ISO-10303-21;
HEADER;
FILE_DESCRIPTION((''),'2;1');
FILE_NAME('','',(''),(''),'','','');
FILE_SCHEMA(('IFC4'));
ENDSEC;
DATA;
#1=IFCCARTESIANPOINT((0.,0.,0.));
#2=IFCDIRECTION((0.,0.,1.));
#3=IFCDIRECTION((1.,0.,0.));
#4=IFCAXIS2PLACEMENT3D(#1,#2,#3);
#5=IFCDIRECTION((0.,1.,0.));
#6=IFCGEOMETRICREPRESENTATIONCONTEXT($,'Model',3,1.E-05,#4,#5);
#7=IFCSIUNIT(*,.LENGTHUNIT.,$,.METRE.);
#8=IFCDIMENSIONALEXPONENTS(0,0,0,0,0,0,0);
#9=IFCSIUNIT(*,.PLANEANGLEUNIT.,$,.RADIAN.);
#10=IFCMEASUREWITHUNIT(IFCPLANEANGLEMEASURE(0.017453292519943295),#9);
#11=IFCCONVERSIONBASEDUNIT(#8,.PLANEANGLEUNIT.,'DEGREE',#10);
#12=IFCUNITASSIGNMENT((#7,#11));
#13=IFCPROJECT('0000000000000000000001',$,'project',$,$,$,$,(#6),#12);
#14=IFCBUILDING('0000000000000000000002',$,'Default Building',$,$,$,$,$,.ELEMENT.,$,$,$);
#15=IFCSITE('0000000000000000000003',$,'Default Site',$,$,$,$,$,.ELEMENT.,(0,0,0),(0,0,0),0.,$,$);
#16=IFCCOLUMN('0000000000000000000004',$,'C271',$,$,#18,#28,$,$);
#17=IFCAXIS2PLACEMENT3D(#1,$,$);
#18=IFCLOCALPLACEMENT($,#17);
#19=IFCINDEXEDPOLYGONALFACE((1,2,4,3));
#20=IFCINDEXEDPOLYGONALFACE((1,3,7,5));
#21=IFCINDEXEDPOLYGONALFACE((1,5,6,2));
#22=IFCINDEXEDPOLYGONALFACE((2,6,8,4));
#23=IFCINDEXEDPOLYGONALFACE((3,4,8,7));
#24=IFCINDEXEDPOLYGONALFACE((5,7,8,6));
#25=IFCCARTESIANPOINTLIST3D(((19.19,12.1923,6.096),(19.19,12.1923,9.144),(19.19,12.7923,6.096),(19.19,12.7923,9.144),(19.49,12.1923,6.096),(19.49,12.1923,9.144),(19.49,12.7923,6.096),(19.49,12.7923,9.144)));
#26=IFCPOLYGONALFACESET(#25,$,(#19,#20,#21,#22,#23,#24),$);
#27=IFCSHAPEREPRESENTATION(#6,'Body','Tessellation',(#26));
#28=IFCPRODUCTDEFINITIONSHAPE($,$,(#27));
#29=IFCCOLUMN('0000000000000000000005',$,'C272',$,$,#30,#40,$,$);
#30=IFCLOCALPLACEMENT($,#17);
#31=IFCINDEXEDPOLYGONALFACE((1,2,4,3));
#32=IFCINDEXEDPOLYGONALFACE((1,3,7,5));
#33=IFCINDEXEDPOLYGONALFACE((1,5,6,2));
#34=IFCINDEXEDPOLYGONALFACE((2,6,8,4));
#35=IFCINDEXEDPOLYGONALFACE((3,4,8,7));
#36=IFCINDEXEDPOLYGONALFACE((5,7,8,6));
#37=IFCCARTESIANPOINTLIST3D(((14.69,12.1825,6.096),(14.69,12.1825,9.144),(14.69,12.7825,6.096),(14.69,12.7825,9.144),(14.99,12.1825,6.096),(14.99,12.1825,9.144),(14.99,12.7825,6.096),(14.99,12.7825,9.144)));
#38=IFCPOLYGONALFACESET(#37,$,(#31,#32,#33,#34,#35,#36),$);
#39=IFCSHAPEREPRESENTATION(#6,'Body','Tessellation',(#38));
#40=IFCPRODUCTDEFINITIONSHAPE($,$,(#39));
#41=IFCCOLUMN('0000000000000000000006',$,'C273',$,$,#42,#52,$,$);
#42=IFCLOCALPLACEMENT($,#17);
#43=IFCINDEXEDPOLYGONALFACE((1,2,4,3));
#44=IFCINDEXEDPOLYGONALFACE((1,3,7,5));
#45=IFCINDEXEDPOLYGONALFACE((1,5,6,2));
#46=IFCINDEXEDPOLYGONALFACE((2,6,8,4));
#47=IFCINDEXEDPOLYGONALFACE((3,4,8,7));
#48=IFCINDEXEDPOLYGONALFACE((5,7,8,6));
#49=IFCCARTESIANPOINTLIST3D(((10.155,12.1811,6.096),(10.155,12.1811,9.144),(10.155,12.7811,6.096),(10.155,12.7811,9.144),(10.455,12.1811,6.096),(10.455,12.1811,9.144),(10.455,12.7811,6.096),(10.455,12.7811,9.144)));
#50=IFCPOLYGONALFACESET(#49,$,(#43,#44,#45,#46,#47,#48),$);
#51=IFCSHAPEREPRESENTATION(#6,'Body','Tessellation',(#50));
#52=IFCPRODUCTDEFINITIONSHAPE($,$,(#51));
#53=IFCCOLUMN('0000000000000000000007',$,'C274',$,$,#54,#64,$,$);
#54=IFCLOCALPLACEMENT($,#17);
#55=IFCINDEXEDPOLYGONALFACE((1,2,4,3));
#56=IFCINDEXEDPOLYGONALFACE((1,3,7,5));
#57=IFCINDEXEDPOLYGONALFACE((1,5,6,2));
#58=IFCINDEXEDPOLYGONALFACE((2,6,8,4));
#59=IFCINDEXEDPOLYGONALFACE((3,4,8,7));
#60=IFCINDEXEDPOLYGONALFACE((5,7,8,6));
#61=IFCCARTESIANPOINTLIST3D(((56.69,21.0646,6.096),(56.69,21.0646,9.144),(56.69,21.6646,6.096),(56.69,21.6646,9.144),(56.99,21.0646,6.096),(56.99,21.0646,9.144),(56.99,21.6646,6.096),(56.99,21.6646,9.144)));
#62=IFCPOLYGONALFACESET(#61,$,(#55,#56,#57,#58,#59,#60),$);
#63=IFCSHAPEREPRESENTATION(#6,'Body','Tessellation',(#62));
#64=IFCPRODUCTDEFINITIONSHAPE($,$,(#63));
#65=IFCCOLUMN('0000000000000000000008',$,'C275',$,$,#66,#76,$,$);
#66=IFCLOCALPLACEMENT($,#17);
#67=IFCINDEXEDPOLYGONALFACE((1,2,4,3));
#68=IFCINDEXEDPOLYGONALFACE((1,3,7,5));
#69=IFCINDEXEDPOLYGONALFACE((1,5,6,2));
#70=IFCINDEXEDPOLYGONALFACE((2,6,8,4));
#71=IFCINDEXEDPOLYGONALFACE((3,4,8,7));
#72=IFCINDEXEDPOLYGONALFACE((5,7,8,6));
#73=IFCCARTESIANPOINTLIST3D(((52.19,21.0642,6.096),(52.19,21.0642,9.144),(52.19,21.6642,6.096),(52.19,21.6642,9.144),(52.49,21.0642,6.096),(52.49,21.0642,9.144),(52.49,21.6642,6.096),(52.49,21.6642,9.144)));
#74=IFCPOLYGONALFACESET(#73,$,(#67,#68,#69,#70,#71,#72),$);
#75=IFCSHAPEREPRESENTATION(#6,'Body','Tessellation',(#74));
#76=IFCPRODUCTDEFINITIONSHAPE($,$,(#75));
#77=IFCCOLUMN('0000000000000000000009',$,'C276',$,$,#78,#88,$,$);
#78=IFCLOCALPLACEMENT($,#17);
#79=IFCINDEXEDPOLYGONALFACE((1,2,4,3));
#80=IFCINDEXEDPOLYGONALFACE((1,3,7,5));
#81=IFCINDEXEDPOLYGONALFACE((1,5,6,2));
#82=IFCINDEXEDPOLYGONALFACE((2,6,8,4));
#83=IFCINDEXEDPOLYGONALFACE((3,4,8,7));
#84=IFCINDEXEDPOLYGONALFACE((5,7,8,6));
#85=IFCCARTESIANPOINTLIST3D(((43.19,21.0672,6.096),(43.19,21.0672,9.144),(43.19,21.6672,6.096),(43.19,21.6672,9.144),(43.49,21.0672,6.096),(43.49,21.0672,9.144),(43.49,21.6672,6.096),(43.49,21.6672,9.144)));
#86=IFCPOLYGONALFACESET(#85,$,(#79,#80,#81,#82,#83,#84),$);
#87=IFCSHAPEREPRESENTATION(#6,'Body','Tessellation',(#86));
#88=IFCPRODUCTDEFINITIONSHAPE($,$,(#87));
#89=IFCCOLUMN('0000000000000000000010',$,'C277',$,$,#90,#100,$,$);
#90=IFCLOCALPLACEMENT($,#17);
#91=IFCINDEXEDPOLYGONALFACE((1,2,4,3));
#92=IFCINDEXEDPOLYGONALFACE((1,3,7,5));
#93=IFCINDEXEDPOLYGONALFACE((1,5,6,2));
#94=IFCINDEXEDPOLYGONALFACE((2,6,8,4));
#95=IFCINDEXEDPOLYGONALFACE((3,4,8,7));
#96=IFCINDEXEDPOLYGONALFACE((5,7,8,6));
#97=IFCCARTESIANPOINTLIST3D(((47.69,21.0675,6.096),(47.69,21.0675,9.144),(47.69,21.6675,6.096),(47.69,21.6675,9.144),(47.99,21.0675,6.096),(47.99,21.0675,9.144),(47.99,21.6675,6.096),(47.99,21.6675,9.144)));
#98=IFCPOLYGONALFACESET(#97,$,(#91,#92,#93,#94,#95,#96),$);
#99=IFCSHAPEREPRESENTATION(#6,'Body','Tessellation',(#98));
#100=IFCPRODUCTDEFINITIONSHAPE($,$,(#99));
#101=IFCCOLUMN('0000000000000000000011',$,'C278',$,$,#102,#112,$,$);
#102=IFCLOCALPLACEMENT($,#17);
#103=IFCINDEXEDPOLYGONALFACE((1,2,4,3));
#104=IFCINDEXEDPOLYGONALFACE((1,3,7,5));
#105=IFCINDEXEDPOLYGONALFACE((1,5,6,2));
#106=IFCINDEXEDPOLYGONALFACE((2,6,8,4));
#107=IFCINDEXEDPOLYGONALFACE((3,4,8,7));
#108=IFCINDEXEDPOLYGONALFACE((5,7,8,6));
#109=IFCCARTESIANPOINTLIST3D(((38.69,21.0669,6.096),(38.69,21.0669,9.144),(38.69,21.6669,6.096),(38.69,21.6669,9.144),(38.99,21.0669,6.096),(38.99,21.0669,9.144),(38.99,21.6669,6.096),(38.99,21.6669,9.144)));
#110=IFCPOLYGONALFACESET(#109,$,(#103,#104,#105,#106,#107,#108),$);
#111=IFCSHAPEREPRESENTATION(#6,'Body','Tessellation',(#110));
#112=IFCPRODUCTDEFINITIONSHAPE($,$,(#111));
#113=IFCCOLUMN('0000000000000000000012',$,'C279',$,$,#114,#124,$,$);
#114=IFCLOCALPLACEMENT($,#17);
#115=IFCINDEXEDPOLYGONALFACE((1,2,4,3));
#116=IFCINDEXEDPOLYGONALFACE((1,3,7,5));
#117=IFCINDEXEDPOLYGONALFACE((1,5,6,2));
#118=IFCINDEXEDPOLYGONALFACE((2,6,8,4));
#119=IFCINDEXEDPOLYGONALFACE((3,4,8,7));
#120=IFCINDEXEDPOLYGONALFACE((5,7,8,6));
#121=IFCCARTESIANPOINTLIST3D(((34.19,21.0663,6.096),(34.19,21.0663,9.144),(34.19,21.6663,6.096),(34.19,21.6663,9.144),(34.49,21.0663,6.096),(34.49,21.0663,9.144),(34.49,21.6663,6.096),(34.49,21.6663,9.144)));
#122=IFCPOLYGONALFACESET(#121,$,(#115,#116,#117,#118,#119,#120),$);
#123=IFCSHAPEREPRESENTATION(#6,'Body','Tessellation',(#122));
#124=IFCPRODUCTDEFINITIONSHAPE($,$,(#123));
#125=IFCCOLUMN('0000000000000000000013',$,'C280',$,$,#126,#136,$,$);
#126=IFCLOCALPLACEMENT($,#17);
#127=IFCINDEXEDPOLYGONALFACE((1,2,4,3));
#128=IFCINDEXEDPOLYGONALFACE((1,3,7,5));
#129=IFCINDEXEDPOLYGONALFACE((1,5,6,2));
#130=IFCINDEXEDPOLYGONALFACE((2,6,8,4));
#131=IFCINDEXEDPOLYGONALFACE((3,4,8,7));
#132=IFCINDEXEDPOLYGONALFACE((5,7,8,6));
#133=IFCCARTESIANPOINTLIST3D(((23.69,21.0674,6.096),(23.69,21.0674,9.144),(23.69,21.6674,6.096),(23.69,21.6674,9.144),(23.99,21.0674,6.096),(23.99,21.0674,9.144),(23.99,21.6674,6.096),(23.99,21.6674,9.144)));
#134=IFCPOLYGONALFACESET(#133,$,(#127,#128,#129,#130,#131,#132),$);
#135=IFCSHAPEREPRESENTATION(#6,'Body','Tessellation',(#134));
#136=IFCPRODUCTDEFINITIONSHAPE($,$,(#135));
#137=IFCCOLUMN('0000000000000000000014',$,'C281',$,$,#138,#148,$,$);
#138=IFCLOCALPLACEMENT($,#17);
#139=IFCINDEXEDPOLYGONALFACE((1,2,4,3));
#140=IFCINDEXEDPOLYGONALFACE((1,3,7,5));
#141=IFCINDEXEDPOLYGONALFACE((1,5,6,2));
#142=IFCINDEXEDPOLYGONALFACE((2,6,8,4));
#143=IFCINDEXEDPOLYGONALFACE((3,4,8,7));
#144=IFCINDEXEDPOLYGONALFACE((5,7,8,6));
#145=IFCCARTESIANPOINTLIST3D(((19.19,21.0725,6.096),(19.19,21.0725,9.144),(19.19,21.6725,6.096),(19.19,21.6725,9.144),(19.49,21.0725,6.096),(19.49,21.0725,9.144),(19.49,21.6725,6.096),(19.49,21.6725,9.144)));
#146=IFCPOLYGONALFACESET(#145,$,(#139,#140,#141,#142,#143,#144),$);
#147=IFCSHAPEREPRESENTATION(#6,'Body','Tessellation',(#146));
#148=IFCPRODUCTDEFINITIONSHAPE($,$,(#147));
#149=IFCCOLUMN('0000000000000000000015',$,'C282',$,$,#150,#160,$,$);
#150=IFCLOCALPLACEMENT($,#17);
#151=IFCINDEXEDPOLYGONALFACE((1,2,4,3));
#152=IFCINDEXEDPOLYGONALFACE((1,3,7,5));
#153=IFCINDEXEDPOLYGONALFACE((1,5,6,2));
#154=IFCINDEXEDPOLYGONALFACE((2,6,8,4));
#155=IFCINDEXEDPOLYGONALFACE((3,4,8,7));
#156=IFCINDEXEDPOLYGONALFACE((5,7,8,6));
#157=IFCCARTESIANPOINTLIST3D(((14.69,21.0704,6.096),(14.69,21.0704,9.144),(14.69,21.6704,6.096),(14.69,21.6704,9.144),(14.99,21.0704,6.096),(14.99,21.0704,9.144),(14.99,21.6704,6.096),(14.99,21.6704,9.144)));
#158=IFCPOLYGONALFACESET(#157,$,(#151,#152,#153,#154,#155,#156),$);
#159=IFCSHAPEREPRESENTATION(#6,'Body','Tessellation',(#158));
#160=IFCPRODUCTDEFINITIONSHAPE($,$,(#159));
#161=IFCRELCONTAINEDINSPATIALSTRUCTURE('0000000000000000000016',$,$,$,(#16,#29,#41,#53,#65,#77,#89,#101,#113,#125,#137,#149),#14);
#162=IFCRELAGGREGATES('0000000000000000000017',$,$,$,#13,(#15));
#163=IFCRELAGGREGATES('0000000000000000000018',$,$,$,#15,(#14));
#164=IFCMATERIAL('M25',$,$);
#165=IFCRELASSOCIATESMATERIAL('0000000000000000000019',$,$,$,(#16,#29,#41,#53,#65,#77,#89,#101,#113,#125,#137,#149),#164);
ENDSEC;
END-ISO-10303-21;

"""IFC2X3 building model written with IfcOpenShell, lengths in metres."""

from ifc_helpers import new_model, entity, si_unit, converted_unit, direction, frame, frame_2d, origin_with_axes, place, context, project, spatial, rectangle, extrude, material, element, save


model = new_model("IFC2X3")

# Units and contexts
model_context = context("Model", 3, precision=1e-05, world=origin_with_axes(), true_north=direction((0.0, 1.0, 0.0)))
ifc_project = project(units=[si_unit("LENGTHUNIT", "METRE"), converted_unit("PLANEANGLEUNIT", "DEGREE", entity("IfcPlaneAngleMeasure", 0.017453292519943295), si_unit("PLANEANGLEUNIT", "RADIAN"), dimensions=[0, 0, 0, 0, 0, 0, 0])], contexts=[model_context])

# Site, building
site = spatial("IfcSite", under=ifc_project, Name="Default Site", CompositionType="ELEMENT", RefLatitude=(0, 0, 0), RefLongitude=(0, 0, 0), RefElevation=0.0)
building = spatial("IfcBuilding", under=site, Name="Default Building", CompositionType="ELEMENT")

# Columns
ifc_material = material(Name="M25")
placement = place(None, origin_with_axes())
element("IfcColumn", 1, at=placement, inside=building, material=ifc_material, Name="C271", context=model_context, shape_type="SweptSolid", body=[
    extrude(rectangle(XDim=0.3, YDim=0.6, at=frame_2d((0.0, 0.0), x_axis=(1.0, 0.0, 0.0))), frame((19.34, 12.4923, 6.096), z_axis=(0.0, 0.0, 1.0), x_axis=(1.0, 0.0, 0.0)), (0.0, 0.0, 1.0), 3.048),
])
element("IfcColumn", 2, at=placement, inside=building, material=ifc_material, Name="C272", context=model_context, shape_type="SweptSolid", body=[
    extrude(rectangle(XDim=0.3, YDim=0.6, at=frame_2d((0.0, 0.0), x_axis=(1.0, 0.0, 0.0))), frame((14.84, 12.4825, 6.096), z_axis=(0.0, 0.0, 1.0), x_axis=(1.0, 0.0, 0.0)), (0.0, 0.0, 1.0), 3.048),
])
element("IfcColumn", 3, at=placement, inside=building, material=ifc_material, Name="C273", context=model_context, shape_type="SweptSolid", body=[
    extrude(rectangle(XDim=0.3, YDim=0.6, at=frame_2d((0.0, 0.0), x_axis=(1.0, 0.0, 0.0))), frame((10.305, 12.4811, 6.096), z_axis=(0.0, 0.0, 1.0), x_axis=(1.0, 0.0, 0.0)), (0.0, 0.0, 1.0), 3.048),
])
element("IfcColumn", 4, at=placement, inside=building, material=ifc_material, Name="C274", context=model_context, shape_type="SweptSolid", body=[
    extrude(rectangle(XDim=0.3, YDim=0.6, at=frame_2d((0.0, 0.0), x_axis=(1.0, 0.0, 0.0))), frame((56.84, 21.3646, 6.096), z_axis=(0.0, 0.0, 1.0), x_axis=(1.0, 0.0, 0.0)), (0.0, 0.0, 1.0), 3.048),
])
element("IfcColumn", 5, at=placement, inside=building, material=ifc_material, Name="C275", context=model_context, shape_type="SweptSolid", body=[
    extrude(rectangle(XDim=0.3, YDim=0.6, at=frame_2d((0.0, 0.0), x_axis=(1.0, 0.0, 0.0))), frame((52.34, 21.3642, 6.096), z_axis=(0.0, 0.0, 1.0), x_axis=(1.0, 0.0, 0.0)), (0.0, 0.0, 1.0), 3.048),
])
element("IfcColumn", 6, at=placement, inside=building, material=ifc_material, Name="C276", context=model_context, shape_type="SweptSolid", body=[
    extrude(rectangle(XDim=0.3, YDim=0.6, at=frame_2d((0.0, 0.0), x_axis=(1.0, 0.0, 0.0))), frame((43.34, 21.3672, 6.096), z_axis=(0.0, 0.0, 1.0), x_axis=(1.0, 0.0, 0.0)), (0.0, 0.0, 1.0), 3.048),
])
element("IfcColumn", 7, at=placement, inside=building, material=ifc_material, Name="C277", context=model_context, shape_type="SweptSolid", body=[
    extrude(rectangle(XDim=0.3, YDim=0.6, at=frame_2d((0.0, 0.0), x_axis=(1.0, 0.0, 0.0))), frame((47.84, 21.3675, 6.096), z_axis=(0.0, 0.0, 1.0), x_axis=(1.0, 0.0, 0.0)), (0.0, 0.0, 1.0), 3.048),
])
element("IfcColumn", 8, at=placement, inside=building, material=ifc_material, Name="C278", context=model_context, shape_type="SweptSolid", body=[
    extrude(rectangle(XDim=0.3, YDim=0.6, at=frame_2d((0.0, 0.0), x_axis=(1.0, 0.0, 0.0))), frame((38.84, 21.3669, 6.096), z_axis=(0.0, 0.0, 1.0), x_axis=(1.0, 0.0, 0.0)), (0.0, 0.0, 1.0), 3.048),
])
element("IfcColumn", 9, at=placement, inside=building, material=ifc_material, Name="C279", context=model_context, shape_type="SweptSolid", body=[
    extrude(rectangle(XDim=0.3, YDim=0.6, at=frame_2d((0.0, 0.0), x_axis=(1.0, 0.0, 0.0))), frame((34.34, 21.3663, 6.096), z_axis=(0.0, 0.0, 1.0), x_axis=(1.0, 0.0, 0.0)), (0.0, 0.0, 1.0), 3.048),
])
element("IfcColumn", 10, at=placement, inside=building, material=ifc_material, Name="C280", context=model_context, shape_type="SweptSolid", body=[
    extrude(rectangle(XDim=0.3, YDim=0.6, at=frame_2d((0.0, 0.0), x_axis=(1.0, 0.0, 0.0))), frame((23.84, 21.3674, 6.096), z_axis=(0.0, 0.0, 1.0), x_axis=(1.0, 0.0, 0.0)), (0.0, 0.0, 1.0), 3.048),
])
element("IfcColumn", 11, at=placement, inside=building, material=ifc_material, Name="C281", context=model_context, shape_type="SweptSolid", body=[
    extrude(rectangle(XDim=0.3, YDim=0.6, at=frame_2d((0.0, 0.0), x_axis=(1.0, 0.0, 0.0))), frame((19.34, 21.3725, 6.096), z_axis=(0.0, 0.0, 1.0), x_axis=(1.0, 0.0, 0.0)), (0.0, 0.0, 1.0), 3.048),
])
element("IfcColumn", 12, at=placement, inside=building, material=ifc_material, Name="C282", context=model_context, shape_type="SweptSolid", body=[
    extrude(rectangle(XDim=0.3, YDim=0.6, at=frame_2d((0.0, 0.0), x_axis=(1.0, 0.0, 0.0))), frame((14.84, 21.3704, 6.096), z_axis=(0.0, 0.0, 1.0), x_axis=(1.0, 0.0, 0.0)), (0.0, 0.0, 1.0), 3.048),
])

save(model, "model.ifc")
